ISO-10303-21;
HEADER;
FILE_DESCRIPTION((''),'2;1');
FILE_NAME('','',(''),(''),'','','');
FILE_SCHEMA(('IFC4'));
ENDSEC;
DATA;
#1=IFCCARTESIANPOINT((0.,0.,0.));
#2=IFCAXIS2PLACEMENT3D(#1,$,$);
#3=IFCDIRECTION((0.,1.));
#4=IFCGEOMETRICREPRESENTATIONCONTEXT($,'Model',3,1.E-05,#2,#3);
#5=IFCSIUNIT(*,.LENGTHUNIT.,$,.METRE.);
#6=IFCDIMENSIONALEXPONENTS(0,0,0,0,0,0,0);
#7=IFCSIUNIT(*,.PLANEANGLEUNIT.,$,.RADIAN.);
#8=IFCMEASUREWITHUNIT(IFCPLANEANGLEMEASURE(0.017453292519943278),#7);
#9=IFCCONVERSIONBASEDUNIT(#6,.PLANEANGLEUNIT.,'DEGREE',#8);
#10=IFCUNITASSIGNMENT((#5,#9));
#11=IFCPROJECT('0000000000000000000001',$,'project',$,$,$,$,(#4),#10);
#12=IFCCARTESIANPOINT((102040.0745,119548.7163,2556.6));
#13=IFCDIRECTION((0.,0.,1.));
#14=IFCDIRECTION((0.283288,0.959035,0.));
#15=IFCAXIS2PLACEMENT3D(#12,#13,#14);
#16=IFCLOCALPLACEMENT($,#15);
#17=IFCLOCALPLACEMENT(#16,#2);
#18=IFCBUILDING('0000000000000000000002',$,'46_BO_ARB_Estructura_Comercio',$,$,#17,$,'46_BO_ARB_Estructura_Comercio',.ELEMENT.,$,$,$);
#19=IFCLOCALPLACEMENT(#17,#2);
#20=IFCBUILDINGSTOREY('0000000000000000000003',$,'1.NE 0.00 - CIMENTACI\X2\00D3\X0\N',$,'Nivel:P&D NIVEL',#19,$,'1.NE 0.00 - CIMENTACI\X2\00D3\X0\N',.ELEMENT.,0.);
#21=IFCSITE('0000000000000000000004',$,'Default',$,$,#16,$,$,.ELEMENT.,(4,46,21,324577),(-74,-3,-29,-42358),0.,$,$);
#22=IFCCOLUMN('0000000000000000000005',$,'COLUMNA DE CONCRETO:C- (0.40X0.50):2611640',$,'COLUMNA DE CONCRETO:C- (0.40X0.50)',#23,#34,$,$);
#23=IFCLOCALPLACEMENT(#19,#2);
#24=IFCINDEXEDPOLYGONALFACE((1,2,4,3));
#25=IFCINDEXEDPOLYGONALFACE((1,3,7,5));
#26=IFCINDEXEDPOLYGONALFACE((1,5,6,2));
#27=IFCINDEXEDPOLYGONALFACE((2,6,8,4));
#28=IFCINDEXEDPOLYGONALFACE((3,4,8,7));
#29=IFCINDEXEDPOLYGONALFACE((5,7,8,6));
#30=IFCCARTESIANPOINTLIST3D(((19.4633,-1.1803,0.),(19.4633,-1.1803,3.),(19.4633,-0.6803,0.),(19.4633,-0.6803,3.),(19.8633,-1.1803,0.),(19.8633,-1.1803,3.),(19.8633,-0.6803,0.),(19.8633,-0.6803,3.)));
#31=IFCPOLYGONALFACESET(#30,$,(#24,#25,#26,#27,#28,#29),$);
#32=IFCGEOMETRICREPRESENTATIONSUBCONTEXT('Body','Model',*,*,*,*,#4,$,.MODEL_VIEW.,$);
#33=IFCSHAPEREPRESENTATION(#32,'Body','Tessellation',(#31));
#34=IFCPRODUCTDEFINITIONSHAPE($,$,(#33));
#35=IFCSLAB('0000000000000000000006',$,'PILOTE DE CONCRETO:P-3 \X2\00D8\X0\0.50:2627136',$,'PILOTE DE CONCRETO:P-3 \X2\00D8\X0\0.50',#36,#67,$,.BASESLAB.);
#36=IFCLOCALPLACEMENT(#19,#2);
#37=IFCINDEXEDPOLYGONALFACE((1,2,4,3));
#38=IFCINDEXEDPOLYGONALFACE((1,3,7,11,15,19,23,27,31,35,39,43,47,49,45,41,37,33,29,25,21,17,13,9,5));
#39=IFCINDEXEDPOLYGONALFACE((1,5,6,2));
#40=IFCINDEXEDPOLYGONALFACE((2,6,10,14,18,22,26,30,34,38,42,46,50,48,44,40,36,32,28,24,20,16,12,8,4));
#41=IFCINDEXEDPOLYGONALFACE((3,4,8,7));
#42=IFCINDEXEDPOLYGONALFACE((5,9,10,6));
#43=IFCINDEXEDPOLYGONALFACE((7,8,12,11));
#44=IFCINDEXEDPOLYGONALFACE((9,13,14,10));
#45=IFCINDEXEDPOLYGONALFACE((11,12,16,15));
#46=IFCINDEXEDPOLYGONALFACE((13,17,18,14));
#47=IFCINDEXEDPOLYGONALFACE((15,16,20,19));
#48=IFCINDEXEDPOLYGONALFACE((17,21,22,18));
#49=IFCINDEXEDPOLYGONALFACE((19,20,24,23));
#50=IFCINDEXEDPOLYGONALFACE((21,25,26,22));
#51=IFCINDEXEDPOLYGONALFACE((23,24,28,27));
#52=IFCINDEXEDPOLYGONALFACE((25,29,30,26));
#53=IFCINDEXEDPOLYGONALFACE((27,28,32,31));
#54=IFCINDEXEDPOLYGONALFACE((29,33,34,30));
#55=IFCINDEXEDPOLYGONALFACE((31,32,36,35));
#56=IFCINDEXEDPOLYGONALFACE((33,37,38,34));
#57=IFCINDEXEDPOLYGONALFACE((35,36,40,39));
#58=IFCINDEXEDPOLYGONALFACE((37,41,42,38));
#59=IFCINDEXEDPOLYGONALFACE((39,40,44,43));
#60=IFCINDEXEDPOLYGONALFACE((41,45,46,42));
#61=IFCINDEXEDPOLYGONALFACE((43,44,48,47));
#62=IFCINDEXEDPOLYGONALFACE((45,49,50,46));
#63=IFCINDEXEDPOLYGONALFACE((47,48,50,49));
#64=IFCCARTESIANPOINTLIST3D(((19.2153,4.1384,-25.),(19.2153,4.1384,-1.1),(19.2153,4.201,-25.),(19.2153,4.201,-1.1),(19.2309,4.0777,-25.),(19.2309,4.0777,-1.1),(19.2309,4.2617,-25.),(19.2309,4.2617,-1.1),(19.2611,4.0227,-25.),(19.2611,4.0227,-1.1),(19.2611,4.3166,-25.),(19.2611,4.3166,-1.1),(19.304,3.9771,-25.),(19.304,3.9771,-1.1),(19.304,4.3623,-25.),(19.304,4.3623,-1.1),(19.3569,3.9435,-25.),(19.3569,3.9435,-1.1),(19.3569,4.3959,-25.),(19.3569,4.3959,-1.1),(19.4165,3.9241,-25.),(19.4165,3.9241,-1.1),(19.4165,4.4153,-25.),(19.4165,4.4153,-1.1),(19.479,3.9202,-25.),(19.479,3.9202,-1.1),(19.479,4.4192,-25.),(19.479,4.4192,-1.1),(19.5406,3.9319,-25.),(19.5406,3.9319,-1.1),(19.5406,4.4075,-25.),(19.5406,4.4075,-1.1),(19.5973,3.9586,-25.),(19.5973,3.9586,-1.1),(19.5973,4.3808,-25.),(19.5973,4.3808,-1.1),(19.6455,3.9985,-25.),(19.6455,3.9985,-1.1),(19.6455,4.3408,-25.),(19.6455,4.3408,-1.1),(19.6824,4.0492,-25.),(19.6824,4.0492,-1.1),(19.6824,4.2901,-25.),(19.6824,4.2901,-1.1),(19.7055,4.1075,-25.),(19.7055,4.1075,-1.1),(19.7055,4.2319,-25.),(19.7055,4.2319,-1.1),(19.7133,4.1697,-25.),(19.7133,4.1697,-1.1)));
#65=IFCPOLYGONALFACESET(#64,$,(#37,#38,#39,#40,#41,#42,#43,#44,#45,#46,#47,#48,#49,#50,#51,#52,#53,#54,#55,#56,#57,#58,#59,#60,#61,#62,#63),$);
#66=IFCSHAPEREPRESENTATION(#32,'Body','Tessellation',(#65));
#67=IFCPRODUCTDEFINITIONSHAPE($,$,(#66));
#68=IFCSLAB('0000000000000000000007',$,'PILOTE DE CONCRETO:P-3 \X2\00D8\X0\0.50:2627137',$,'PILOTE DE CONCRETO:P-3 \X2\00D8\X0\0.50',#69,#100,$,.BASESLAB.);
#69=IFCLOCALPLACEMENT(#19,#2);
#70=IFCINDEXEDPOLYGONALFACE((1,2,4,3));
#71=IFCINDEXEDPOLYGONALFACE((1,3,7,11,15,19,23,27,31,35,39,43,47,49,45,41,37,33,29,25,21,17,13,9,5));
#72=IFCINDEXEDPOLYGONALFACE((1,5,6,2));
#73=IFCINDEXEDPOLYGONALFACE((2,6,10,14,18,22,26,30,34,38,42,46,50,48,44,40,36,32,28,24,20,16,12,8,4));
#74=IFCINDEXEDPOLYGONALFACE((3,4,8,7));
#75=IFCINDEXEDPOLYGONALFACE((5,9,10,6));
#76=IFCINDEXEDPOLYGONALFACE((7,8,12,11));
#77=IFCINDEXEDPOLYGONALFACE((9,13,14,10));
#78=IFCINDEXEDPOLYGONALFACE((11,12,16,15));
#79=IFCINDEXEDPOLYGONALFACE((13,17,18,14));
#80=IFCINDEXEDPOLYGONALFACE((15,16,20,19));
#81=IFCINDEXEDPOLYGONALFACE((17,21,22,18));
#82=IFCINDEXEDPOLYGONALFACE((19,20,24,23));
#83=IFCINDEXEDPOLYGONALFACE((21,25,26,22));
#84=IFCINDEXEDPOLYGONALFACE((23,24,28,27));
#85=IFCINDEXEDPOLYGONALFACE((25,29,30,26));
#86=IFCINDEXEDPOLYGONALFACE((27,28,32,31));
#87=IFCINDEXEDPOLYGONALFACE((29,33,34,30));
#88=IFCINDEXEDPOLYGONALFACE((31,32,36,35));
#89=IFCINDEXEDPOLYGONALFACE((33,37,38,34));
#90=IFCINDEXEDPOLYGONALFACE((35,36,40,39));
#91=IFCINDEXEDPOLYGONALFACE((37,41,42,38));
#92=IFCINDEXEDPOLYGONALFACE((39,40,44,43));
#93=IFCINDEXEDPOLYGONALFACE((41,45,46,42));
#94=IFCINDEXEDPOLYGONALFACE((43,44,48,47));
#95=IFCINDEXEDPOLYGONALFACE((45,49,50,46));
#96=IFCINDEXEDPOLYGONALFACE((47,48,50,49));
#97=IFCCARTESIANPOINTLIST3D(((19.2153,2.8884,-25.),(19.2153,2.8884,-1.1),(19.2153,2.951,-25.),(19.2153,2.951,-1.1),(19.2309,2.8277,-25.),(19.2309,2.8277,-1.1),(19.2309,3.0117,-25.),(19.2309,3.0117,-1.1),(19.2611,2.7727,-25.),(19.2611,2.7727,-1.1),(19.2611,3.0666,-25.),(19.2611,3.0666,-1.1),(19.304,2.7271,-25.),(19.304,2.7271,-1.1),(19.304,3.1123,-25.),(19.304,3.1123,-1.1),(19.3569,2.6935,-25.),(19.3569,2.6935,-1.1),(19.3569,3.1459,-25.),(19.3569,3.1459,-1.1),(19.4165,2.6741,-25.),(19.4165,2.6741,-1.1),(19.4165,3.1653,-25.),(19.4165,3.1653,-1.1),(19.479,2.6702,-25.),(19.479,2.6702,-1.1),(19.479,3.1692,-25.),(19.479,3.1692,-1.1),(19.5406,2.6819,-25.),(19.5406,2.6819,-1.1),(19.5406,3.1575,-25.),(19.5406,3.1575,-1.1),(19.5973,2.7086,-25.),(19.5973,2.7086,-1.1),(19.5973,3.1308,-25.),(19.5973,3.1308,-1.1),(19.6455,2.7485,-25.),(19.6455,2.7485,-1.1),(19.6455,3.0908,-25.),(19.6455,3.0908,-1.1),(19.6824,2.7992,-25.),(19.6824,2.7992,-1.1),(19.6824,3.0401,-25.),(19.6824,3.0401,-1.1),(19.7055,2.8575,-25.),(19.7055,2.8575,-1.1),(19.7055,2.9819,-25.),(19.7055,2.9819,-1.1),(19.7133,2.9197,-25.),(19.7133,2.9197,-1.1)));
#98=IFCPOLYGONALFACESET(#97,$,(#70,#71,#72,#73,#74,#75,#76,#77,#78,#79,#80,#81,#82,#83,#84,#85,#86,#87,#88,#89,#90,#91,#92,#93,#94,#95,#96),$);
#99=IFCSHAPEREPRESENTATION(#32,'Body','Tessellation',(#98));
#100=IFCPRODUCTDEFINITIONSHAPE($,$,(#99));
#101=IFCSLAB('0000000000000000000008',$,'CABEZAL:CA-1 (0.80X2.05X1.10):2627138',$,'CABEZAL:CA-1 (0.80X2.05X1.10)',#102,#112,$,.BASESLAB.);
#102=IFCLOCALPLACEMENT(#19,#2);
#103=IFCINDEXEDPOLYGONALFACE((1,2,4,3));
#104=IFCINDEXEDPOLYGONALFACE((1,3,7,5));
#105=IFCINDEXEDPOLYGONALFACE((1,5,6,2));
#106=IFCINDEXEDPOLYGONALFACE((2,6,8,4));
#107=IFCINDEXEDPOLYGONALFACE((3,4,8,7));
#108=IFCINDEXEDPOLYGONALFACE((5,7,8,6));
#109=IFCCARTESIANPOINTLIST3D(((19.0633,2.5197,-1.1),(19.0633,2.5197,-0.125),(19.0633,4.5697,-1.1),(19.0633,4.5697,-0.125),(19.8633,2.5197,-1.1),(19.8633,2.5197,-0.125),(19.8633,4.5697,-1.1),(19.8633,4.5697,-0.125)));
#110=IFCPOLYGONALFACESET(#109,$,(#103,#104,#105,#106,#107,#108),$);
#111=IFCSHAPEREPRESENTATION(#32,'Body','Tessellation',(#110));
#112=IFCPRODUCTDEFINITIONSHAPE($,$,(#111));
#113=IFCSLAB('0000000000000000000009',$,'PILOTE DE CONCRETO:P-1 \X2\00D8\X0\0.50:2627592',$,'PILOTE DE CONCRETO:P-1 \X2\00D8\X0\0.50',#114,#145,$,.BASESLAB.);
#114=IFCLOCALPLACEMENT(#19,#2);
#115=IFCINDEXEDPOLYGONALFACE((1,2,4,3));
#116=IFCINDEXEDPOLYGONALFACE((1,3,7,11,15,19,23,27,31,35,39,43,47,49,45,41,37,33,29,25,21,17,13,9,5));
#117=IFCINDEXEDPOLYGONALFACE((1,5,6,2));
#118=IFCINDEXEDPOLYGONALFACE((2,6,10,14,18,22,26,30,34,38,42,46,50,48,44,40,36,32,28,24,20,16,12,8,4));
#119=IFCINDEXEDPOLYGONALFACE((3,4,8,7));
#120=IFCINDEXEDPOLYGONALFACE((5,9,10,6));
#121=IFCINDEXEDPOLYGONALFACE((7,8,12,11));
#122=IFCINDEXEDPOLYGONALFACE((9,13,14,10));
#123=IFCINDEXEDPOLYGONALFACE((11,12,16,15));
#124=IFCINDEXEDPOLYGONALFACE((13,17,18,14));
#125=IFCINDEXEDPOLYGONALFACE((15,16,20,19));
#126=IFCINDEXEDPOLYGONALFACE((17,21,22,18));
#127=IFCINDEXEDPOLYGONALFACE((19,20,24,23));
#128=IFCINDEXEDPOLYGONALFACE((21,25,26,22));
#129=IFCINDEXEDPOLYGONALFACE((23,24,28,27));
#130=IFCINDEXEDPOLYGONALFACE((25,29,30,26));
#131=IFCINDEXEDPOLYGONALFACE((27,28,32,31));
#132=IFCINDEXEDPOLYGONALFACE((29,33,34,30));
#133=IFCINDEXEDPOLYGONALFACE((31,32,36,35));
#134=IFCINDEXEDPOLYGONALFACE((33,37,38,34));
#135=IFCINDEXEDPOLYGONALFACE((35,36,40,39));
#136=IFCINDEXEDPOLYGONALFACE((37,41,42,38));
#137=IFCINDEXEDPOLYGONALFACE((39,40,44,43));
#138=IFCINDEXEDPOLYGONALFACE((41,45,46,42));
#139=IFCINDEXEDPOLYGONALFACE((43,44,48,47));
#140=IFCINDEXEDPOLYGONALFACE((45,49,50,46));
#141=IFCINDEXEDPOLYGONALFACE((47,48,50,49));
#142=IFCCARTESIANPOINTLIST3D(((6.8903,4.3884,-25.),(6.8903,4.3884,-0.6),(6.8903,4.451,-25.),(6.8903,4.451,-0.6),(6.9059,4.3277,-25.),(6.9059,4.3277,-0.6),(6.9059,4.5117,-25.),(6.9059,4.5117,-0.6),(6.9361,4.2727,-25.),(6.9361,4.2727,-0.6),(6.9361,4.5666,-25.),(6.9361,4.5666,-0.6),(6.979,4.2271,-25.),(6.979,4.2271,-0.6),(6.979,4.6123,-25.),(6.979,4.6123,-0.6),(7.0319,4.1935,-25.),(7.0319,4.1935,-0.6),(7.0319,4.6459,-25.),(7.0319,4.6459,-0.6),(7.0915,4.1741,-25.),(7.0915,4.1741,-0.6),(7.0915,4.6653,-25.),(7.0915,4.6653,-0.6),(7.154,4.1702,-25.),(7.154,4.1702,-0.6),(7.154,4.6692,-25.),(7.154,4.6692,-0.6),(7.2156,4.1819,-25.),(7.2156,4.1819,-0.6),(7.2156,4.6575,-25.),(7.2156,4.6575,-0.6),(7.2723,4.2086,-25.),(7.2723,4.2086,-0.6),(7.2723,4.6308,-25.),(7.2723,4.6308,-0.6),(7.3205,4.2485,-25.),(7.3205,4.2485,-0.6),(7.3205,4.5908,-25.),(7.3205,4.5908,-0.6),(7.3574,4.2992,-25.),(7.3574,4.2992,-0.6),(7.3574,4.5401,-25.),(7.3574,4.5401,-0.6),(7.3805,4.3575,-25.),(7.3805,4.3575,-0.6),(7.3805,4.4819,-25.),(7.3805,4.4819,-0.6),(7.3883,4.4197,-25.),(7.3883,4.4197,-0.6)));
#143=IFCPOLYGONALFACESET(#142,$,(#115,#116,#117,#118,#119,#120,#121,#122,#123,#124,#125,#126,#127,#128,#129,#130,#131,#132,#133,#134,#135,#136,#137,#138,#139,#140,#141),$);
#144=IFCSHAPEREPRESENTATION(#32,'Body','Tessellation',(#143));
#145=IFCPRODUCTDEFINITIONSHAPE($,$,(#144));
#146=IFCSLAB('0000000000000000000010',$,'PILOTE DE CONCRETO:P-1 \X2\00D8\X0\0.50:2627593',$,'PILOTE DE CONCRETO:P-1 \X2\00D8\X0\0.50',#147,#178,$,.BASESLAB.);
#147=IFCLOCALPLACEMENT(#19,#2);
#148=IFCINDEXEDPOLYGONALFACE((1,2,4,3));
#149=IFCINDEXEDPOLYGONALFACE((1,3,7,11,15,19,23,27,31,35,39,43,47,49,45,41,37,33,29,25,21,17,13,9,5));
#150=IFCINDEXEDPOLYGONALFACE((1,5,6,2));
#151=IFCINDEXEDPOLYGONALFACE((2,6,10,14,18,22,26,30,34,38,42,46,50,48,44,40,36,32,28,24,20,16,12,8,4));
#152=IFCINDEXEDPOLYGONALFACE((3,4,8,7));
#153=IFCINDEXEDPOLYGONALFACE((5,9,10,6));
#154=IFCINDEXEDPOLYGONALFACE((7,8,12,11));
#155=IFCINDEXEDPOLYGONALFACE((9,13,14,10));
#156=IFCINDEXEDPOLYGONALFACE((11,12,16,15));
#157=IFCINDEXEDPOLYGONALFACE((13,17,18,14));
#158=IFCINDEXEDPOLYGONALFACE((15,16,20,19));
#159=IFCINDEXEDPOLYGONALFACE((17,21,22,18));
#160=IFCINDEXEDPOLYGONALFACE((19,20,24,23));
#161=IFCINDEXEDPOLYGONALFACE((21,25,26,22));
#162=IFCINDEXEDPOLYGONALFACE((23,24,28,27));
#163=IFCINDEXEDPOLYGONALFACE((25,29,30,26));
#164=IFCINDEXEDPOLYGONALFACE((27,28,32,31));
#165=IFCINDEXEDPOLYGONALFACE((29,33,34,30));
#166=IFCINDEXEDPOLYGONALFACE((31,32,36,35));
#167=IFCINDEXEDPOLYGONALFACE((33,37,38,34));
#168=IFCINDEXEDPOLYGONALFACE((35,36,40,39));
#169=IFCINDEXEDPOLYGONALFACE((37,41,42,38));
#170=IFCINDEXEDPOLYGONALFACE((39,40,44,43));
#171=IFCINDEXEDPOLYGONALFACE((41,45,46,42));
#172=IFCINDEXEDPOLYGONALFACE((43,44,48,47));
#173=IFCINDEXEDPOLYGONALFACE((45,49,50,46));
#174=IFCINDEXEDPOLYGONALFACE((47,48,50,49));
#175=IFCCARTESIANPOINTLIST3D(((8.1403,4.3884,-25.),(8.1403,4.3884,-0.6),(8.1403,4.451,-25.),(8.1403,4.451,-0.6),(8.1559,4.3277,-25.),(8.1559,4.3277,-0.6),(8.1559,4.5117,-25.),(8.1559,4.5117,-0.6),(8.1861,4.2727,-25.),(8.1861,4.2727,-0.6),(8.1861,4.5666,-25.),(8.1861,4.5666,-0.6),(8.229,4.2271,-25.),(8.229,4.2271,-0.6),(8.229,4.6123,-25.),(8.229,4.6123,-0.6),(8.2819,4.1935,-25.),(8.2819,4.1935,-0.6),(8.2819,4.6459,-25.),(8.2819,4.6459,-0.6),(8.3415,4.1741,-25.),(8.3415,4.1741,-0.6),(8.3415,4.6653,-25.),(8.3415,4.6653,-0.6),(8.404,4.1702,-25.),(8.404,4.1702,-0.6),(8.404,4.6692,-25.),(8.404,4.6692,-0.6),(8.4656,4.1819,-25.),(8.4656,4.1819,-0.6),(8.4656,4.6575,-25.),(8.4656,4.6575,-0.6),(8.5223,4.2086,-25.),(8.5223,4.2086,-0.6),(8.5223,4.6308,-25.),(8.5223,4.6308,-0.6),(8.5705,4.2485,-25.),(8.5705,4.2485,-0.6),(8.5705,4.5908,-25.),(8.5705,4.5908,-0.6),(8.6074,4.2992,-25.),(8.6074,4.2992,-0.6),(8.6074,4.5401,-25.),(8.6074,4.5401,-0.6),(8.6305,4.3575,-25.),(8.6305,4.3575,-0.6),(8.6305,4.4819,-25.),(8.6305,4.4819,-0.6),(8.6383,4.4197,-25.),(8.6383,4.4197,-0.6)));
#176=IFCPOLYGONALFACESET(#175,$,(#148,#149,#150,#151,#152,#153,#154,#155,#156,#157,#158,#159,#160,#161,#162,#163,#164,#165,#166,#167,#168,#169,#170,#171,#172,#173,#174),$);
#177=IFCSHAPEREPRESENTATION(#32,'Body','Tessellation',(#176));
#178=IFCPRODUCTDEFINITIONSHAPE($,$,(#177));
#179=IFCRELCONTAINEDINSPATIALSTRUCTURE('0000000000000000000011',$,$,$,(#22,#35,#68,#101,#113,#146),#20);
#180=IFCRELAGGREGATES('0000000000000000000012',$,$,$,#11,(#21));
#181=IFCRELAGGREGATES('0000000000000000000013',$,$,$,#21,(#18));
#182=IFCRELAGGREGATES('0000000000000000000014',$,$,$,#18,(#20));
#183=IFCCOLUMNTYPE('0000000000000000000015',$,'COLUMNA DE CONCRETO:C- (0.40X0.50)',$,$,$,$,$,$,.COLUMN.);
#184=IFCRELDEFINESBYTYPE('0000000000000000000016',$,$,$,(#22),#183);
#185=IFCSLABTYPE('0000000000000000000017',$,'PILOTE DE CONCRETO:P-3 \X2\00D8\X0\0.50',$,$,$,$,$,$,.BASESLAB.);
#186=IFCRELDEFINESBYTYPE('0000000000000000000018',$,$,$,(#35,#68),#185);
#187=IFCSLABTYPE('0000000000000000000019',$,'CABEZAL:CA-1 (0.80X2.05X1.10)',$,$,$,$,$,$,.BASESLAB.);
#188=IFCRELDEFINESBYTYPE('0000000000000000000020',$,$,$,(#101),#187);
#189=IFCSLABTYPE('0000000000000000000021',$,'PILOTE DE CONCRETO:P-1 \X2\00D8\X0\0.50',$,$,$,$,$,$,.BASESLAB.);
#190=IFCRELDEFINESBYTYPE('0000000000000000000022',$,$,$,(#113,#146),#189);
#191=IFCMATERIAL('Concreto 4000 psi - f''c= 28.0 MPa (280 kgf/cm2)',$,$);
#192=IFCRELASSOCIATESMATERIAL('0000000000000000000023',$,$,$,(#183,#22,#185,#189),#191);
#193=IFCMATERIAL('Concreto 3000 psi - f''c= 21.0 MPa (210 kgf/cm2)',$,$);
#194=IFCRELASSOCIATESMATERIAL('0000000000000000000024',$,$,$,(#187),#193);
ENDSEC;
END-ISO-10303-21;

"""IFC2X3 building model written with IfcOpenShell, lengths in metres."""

from ifc_helpers import new_model, entity, si_unit, converted_unit, direction, frame, frame_2d, origin, origin_2d_with_axis, place, context, subcontext, project, spatial, rectangle, circle, extrude, source, transform, mapped, material, type_object, type_shapes, element, save


model = new_model("IFC2X3")

# Units and contexts
model_context = context("Model", 3, precision=1e-05, world=origin(), true_north=direction((0.0, 1.0)))
body_context = subcontext(model_context, "Body", "Model", "MODEL_VIEW")
ifc_project = project(units=[si_unit("LENGTHUNIT", "METRE"), converted_unit("PLANEANGLEUNIT", "DEGREE", entity("IfcPlaneAngleMeasure", 0.017453292519943278), si_unit("PLANEANGLEUNIT", "RADIAN"), dimensions=[0, 0, 0, 0, 0, 0, 0])], contexts=[model_context])

# Site, building, storey
site_placement = place(None, frame((102040.0745, 119548.7163, 2556.6), z_axis=(0.0, 0.0, 1.0), x_axis=(0.283288, 0.959035, 0.0)))
site = spatial("IfcSite", under=ifc_project, at=site_placement, Name="Default", CompositionType="ELEMENT", RefLatitude=(4, 46, 21, 324577), RefLongitude=(-74, -3, -29, -42358), RefElevation=0.0)
building_placement = place(site_placement, origin())
building = spatial("IfcBuilding", under=site, at=building_placement, Name="46_BO_ARB_Estructura_Comercio", LongName="46_BO_ARB_Estructura_Comercio", CompositionType="ELEMENT")
storey_placement = place(building_placement, origin())
storey = spatial("IfcBuildingStorey", under=building, at=storey_placement, Name="1.NE 0.00 - CIMENTACIÓN", ObjectType="Nivel:P&D NIVEL", LongName="1.NE 0.00 - CIMENTACIÓN", CompositionType="ELEMENT", Elevation=0.0)

# Column
ifc_material_1 = material(Name="Concreto 4000 psi - f'c= 28.0 MPa (280 kgf/cm2)")
column_type_1 = type_object("IfcColumnType", Name="COLUMNA DE CONCRETO:C- (0.40X0.50)", PredefinedType="COLUMN", material=ifc_material_1)
shared_shape_1 = source(origin(), body_context, "Body", "SweptSolid", [
    extrude(rectangle(XDim=0.5, YDim=0.4, at=frame_2d((0.0, 0.0), x_axis=(1.0, 0.0))), frame((19.6633, -0.9303, 0.0), z_axis=(0.0, 0.0, 1.0), x_axis=(0.0, -1.0, 0.0)), (0.0, 0.0, 1.0), 3.0),
])
type_shapes(column_type_1, [shared_shape_1])
column_1_placement = place(storey_placement, origin())
element("IfcColumn", 1, at=column_1_placement, inside=storey, type_object=column_type_1, material=ifc_material_1, Name="COLUMNA DE CONCRETO:C- (0.40X0.50):2611640", ObjectType="COLUMNA DE CONCRETO:C- (0.40X0.50)", context=body_context, shape_type="MappedRepresentation", body=[
    mapped(shared_shape_1, transform((0.0, 0.0, 0.0), scale=1.0)),
])

# Shared definitions
ifc_material_2 = material(Name="Concreto 3000 psi - f'c= 21.0 MPa (210 kgf/cm2)")

# Slabs
slab_type_1 = type_object("IfcSlabType", Name="PILOTE DE CONCRETO:P-3 Ø0.50", PredefinedType="BASESLAB", material=ifc_material_1)
slab_1_placement = place(storey_placement, origin())
element("IfcSlab", 2, at=slab_1_placement, inside=storey, type_object=slab_type_1, Name="PILOTE DE CONCRETO:P-3 Ø0.50:2627136", ObjectType="PILOTE DE CONCRETO:P-3 Ø0.50", PredefinedType="BASESLAB", context=body_context, shape_type="SweptSolid", body=[
    extrude(circle(Radius=0.25, at=frame_2d((0.0, 0.0), x_axis=(1.0, 0.0))), frame((19.4633, 4.1697, -25.0)), (0.0, 0.0, 1.0), 23.9),
])
slab_2_placement = place(storey_placement, origin())
element("IfcSlab", 3, at=slab_2_placement, inside=storey, type_object=slab_type_1, Name="PILOTE DE CONCRETO:P-3 Ø0.50:2627137", ObjectType="PILOTE DE CONCRETO:P-3 Ø0.50", PredefinedType="BASESLAB", context=body_context, shape_type="SweptSolid", body=[
    extrude(circle(Radius=0.25, at=frame_2d((0.0, 0.0), x_axis=(1.0, 0.0))), frame((19.4633, 2.9197, -25.0)), (0.0, 0.0, 1.0), 23.9),
])
slab_type_2 = type_object("IfcSlabType", Name="CABEZAL:CA-1 (0.80X2.05X1.10)", PredefinedType="BASESLAB", material=ifc_material_2)
slab_3_placement = place(storey_placement, origin())
element("IfcSlab", 4, at=slab_3_placement, inside=storey, type_object=slab_type_2, Name="CABEZAL:CA-1 (0.80X2.05X1.10):2627138", ObjectType="CABEZAL:CA-1 (0.80X2.05X1.10)", PredefinedType="BASESLAB", context=body_context, shape_type="SweptSolid", body=[
    extrude(rectangle(XDim=0.8, YDim=2.05, at=origin_2d_with_axis()), frame((19.4633, 3.5447, -1.1), z_axis=(0.0, 0.0, 1.0), x_axis=(-1.0, 0.0, 0.0)), (0.0, 0.0, 1.0), 0.975),
])
slab_type_3 = type_object("IfcSlabType", Name="PILOTE DE CONCRETO:P-1 Ø0.50", PredefinedType="BASESLAB", material=ifc_material_1)
slab_4_placement = place(storey_placement, origin())
element("IfcSlab", 5, at=slab_4_placement, inside=storey, type_object=slab_type_3, Name="PILOTE DE CONCRETO:P-1 Ø0.50:2627592", ObjectType="PILOTE DE CONCRETO:P-1 Ø0.50", PredefinedType="BASESLAB", context=body_context, shape_type="SweptSolid", body=[
    extrude(circle(Radius=0.25, at=frame_2d((0.0, 0.0), x_axis=(1.0, 0.0))), frame((7.1383, 4.4197, -25.0)), (0.0, 0.0, 1.0), 24.4),
])
slab_5_placement = place(storey_placement, origin())
element("IfcSlab", 6, at=slab_5_placement, inside=storey, type_object=slab_type_3, Name="PILOTE DE CONCRETO:P-1 Ø0.50:2627593", ObjectType="PILOTE DE CONCRETO:P-1 Ø0.50", PredefinedType="BASESLAB", context=body_context, shape_type="SweptSolid", body=[
    extrude(circle(Radius=0.25, at=frame_2d((0.0, 0.0), x_axis=(1.0, 0.0))), frame((8.3883, 4.4197, -25.0)), (0.0, 0.0, 1.0), 24.4),
])

save(model, "model.ifc")
